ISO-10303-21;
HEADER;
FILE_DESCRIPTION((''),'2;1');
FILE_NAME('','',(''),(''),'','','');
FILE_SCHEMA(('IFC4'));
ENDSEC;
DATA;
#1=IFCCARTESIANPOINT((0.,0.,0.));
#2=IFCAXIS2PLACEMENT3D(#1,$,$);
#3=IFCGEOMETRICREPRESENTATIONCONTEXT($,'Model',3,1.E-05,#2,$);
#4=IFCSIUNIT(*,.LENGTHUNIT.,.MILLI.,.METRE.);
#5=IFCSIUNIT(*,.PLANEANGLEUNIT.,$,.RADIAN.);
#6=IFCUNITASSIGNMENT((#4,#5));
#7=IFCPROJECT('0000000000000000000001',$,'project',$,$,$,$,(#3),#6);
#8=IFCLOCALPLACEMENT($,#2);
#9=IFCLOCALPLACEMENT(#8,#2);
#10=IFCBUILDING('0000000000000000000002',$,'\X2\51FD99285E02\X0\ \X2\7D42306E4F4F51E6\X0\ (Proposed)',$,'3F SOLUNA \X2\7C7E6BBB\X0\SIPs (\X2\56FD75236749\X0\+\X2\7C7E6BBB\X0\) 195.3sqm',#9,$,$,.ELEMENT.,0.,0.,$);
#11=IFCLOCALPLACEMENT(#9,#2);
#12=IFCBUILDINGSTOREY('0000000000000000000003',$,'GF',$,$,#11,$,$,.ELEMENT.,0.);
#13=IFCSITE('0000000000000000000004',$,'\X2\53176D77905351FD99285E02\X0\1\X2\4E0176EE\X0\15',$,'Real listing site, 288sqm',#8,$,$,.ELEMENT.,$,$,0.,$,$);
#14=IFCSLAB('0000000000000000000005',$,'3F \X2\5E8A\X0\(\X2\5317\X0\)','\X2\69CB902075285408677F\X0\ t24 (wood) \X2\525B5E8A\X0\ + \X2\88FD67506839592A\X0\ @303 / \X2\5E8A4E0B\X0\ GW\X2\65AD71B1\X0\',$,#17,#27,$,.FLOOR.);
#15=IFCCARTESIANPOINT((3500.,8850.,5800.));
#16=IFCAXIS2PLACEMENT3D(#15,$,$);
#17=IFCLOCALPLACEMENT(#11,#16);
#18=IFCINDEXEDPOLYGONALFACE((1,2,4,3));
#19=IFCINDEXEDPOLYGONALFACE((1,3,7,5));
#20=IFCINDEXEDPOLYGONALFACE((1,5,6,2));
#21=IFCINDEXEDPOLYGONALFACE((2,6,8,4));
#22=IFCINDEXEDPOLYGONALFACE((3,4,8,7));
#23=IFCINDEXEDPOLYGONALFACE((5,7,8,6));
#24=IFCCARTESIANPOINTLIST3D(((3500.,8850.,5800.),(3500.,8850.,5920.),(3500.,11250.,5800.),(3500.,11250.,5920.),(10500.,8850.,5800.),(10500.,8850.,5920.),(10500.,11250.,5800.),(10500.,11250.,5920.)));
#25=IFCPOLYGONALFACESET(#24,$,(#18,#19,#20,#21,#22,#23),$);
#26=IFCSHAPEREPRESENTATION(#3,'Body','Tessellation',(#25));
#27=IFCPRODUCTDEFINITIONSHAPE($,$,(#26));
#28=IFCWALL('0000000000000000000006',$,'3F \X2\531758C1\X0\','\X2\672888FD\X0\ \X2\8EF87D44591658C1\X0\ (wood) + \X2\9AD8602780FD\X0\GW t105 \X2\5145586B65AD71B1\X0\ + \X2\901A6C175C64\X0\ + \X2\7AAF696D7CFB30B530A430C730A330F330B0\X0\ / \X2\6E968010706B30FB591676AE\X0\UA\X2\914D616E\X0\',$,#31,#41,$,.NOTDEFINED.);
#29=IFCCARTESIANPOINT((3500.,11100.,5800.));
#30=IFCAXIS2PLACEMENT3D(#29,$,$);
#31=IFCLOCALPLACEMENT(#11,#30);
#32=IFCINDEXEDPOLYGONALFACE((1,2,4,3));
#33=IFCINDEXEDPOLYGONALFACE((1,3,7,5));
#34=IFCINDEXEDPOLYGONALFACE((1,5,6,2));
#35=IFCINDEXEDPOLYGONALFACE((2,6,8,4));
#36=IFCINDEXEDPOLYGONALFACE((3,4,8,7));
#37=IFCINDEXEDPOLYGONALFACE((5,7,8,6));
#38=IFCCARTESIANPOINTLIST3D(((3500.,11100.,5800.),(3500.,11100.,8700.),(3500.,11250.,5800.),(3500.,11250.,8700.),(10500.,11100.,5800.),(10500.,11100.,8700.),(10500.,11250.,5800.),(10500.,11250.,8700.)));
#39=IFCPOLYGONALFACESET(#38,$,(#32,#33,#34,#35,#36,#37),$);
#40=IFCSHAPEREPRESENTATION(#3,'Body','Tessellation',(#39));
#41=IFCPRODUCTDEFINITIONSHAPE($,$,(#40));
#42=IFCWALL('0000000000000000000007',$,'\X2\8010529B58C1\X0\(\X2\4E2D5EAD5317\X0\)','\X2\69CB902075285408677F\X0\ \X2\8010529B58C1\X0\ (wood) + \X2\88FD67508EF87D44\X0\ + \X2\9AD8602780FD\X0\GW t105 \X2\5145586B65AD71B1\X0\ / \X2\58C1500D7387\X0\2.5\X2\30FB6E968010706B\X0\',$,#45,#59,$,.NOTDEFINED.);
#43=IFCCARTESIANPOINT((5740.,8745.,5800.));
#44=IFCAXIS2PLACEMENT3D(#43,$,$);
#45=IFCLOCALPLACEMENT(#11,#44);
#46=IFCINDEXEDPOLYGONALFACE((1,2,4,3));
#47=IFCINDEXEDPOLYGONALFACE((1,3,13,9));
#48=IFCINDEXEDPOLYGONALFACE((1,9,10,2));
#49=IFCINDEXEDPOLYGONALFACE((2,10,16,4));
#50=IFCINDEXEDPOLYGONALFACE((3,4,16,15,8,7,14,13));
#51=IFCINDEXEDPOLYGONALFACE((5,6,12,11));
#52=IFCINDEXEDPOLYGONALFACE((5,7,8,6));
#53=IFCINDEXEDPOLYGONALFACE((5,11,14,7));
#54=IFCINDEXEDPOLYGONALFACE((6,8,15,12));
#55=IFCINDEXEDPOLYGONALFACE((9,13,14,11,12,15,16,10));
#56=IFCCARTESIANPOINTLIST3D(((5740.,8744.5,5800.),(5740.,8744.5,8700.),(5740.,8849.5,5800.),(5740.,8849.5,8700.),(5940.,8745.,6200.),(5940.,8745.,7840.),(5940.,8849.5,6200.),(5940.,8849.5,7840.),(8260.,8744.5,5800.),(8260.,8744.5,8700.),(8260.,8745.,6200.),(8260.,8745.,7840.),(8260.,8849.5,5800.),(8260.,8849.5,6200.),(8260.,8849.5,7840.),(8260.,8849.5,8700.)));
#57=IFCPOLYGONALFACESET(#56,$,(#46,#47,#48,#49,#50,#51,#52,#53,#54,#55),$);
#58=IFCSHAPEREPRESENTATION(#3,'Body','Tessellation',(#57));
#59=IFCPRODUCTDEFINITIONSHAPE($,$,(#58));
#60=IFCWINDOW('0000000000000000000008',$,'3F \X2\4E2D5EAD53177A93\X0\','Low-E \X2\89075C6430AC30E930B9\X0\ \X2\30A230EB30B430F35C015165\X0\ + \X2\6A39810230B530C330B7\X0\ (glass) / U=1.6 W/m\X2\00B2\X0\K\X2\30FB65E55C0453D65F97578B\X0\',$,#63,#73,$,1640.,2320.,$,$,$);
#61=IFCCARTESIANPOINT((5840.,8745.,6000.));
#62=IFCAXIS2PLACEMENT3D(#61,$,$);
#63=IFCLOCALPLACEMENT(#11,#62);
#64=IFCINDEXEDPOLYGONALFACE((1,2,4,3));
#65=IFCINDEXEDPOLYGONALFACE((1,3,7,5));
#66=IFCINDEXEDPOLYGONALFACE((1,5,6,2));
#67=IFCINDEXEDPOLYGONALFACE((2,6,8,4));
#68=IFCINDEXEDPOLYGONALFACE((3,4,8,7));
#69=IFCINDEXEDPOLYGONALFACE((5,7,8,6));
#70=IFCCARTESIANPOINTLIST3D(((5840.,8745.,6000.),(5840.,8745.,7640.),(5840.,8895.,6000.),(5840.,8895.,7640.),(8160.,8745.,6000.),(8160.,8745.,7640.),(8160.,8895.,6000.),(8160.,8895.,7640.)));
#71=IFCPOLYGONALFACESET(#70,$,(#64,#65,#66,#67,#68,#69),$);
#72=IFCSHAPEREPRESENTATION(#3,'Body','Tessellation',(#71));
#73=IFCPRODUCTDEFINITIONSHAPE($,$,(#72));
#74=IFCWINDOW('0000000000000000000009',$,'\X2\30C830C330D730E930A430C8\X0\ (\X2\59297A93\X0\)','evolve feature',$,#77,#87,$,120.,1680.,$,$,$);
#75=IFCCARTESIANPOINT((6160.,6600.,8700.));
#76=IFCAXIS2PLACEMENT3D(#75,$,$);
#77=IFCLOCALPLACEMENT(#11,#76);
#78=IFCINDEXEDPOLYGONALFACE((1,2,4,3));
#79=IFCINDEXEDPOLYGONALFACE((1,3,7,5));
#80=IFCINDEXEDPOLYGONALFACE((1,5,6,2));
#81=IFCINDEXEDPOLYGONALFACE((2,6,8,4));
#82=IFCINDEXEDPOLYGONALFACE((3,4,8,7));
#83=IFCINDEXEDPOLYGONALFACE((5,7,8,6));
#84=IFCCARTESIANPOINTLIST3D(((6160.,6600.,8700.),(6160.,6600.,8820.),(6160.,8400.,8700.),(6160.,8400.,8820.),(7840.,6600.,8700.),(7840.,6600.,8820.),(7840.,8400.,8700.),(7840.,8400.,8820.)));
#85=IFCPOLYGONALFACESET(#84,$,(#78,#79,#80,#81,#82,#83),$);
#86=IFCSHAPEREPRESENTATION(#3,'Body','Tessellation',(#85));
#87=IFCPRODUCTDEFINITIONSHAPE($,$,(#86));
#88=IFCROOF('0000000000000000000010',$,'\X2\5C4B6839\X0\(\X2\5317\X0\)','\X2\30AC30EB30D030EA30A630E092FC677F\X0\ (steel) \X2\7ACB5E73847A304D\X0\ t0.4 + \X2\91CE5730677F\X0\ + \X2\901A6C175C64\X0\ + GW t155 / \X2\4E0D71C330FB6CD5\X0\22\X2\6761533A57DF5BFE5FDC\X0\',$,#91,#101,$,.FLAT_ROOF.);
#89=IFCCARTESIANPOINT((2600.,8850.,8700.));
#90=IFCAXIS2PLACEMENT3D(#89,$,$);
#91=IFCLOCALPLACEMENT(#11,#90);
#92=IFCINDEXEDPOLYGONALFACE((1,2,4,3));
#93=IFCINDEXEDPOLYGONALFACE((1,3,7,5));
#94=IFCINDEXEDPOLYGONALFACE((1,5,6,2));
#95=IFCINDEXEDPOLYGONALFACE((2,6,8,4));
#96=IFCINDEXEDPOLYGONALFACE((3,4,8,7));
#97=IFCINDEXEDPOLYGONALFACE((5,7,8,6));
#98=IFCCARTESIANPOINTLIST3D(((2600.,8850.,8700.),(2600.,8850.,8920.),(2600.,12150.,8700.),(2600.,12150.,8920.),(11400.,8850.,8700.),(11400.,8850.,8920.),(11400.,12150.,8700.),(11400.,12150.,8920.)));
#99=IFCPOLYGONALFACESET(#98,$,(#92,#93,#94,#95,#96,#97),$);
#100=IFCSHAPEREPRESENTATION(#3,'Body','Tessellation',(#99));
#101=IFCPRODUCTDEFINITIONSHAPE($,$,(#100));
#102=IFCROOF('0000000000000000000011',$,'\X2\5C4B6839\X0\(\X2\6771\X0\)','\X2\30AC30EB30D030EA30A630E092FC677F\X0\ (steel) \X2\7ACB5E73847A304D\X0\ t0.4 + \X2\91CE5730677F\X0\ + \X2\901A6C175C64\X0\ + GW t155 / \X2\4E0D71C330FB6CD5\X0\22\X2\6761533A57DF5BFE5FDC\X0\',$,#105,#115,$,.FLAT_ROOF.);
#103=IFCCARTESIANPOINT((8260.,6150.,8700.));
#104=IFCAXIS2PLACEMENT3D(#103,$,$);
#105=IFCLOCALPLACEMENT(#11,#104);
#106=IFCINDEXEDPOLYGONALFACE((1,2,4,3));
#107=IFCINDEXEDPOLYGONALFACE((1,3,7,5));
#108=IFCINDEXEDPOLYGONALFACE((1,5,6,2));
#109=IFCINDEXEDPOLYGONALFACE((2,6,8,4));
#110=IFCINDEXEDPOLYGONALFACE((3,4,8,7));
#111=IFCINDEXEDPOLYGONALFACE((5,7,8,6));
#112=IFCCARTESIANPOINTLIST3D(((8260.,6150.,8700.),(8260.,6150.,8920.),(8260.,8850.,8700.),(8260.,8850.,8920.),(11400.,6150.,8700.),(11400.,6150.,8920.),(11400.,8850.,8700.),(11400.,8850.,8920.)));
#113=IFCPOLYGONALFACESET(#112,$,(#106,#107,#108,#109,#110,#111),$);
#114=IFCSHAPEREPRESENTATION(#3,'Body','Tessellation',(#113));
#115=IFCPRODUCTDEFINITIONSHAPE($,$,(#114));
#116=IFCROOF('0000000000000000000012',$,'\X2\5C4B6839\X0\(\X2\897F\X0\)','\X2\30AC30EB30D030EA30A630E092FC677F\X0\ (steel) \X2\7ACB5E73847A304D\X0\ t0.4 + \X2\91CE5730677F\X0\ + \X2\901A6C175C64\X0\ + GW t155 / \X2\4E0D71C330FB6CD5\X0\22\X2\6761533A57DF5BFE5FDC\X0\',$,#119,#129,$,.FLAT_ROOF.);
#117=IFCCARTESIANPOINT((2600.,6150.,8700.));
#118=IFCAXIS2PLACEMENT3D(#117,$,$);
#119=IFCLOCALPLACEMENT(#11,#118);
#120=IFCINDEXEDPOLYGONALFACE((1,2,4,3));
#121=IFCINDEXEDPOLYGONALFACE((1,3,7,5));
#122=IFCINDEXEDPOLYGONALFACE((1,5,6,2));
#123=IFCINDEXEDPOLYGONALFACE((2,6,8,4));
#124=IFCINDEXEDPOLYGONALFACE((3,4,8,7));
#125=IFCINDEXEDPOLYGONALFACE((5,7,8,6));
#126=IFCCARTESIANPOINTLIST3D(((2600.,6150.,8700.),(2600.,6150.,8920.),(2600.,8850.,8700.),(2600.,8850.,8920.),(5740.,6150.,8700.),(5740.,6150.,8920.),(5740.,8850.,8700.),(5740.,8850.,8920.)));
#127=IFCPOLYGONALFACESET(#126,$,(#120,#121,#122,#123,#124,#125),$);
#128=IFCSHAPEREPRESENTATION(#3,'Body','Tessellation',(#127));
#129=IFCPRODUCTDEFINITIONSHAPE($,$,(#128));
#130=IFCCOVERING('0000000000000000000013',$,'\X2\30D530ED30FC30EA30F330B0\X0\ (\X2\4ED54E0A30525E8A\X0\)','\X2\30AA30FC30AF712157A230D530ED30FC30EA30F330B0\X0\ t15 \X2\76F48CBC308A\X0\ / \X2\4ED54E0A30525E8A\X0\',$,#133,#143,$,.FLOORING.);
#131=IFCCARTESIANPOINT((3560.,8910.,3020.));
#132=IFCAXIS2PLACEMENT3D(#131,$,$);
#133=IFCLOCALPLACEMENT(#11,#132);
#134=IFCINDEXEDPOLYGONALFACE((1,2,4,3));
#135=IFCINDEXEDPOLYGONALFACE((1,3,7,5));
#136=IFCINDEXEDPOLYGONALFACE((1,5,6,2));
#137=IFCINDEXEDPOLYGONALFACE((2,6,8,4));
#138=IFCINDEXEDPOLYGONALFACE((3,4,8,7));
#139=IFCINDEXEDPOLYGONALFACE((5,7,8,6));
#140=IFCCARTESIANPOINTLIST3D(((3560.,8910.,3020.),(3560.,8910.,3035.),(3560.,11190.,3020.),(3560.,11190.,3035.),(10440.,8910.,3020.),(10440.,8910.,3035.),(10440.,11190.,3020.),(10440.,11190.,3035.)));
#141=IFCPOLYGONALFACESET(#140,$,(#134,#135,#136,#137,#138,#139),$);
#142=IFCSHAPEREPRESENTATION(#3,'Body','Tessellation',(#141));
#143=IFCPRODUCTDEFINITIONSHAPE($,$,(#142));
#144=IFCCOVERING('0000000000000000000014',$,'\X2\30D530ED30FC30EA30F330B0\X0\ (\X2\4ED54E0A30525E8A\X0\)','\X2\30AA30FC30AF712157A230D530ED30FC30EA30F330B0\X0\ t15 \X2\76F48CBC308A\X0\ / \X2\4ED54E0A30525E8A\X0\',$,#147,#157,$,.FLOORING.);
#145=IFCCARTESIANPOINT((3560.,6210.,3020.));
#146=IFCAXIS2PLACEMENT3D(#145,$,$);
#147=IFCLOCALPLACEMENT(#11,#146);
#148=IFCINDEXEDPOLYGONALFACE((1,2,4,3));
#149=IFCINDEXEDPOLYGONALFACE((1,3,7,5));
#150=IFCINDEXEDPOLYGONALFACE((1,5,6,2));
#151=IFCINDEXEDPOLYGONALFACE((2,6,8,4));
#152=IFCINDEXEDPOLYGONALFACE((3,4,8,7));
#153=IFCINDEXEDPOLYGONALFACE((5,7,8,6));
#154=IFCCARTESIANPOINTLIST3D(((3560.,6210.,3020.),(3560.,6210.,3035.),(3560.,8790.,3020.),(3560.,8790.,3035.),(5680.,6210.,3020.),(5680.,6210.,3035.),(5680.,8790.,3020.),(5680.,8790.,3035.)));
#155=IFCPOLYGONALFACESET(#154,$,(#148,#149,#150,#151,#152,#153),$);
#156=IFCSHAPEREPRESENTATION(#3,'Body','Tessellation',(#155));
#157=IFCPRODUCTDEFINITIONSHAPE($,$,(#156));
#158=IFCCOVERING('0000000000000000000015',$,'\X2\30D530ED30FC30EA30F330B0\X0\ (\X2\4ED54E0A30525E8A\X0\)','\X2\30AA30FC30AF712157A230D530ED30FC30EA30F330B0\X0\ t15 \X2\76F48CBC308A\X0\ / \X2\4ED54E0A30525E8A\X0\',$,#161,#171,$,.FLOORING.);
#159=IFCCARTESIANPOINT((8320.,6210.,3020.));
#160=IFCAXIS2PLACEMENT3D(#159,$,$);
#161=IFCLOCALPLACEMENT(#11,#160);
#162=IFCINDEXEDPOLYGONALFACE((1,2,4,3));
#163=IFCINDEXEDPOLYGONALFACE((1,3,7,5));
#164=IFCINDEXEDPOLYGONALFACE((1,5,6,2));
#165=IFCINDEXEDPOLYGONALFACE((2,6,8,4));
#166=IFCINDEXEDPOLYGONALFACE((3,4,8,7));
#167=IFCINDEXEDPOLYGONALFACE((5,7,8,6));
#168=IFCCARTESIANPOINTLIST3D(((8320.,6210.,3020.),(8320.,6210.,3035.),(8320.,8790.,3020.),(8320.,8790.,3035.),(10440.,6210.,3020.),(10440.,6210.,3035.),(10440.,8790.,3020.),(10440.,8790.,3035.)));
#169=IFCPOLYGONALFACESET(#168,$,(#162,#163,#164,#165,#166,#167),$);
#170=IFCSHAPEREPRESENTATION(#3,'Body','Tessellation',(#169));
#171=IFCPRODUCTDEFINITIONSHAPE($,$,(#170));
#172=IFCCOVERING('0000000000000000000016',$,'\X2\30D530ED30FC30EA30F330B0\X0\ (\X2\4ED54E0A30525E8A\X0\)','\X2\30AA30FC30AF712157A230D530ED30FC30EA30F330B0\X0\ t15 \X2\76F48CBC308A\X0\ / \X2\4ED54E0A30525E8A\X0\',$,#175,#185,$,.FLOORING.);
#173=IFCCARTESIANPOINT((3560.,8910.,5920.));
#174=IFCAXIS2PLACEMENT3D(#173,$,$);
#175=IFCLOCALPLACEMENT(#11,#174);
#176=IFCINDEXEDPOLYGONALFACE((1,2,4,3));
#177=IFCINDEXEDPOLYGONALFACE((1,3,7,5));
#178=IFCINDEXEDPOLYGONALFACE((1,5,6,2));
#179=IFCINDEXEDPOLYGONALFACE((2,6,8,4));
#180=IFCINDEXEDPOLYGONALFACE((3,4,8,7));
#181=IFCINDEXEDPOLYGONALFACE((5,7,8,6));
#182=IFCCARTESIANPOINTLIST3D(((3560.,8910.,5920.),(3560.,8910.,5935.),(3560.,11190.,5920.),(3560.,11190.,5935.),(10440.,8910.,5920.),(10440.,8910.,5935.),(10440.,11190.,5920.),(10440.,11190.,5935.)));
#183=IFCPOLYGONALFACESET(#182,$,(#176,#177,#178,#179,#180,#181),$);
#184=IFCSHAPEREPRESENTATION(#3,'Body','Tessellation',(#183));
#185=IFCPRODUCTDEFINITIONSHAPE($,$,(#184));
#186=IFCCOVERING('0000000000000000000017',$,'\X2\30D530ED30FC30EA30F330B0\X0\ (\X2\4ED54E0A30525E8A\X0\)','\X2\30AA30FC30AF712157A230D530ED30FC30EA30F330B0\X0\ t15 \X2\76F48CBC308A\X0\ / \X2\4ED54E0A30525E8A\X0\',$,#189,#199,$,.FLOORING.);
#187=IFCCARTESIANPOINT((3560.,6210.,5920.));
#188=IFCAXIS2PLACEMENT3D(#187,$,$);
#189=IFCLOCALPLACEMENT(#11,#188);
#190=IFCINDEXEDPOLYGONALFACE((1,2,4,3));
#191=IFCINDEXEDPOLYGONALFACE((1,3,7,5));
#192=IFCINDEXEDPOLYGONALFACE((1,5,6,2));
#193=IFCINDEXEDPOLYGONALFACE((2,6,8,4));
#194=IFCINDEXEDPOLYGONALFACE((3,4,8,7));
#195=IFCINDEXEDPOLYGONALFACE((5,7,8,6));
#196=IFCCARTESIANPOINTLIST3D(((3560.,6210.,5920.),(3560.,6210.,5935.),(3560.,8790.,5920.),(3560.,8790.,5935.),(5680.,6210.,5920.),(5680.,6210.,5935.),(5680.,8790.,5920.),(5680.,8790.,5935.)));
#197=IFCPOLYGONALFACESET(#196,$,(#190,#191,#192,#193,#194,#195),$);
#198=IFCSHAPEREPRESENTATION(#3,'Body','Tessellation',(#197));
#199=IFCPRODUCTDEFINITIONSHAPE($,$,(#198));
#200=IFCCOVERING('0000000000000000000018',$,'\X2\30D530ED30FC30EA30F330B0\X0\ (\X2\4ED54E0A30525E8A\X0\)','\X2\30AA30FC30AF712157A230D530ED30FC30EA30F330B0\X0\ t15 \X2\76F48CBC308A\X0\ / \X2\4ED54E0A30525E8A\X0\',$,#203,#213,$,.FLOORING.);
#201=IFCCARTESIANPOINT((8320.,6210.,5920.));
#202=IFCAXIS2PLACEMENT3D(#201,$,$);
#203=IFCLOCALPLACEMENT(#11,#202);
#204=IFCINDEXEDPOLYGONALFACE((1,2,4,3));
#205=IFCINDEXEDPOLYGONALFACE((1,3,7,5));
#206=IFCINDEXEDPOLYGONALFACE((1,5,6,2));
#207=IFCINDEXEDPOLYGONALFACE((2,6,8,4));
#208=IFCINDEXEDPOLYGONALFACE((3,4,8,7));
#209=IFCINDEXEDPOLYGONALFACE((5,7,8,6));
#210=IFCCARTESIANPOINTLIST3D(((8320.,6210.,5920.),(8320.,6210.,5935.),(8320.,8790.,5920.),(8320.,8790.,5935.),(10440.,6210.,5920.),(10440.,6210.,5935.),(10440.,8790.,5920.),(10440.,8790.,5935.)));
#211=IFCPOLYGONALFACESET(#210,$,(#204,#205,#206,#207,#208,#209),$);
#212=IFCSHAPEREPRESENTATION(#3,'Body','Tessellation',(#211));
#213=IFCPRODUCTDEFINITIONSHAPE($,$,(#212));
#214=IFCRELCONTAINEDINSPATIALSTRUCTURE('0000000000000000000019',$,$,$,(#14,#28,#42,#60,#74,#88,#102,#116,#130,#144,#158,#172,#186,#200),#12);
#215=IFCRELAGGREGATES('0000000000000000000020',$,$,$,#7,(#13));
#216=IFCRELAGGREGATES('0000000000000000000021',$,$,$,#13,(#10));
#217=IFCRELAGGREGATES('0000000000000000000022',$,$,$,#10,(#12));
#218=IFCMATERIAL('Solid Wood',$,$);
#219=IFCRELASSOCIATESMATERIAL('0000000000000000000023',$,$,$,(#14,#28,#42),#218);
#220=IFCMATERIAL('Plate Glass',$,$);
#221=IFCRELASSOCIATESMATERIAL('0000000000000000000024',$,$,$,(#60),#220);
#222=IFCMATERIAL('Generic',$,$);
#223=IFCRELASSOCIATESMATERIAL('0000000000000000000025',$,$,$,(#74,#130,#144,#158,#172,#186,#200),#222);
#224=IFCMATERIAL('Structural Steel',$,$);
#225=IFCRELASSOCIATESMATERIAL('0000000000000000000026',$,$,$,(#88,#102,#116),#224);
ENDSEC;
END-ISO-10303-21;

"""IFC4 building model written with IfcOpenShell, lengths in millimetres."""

from ifc_helpers import new_model, si_unit, frame, frame_2d, origin, place, context, project, spatial, rectangle, extrude, material, element, fill, save


model = new_model("IFC4")

# Units and contexts
model_context = context("Model", 3, precision=1e-05, world=origin())
ifc_project = project(units=[si_unit("LENGTHUNIT", "METRE", prefix="MILLI"), si_unit("PLANEANGLEUNIT", "RADIAN")], contexts=[model_context])

# Site, building, storey
site_placement = place(None, origin())
site = spatial("IfcSite", under=ifc_project, at=site_placement, Name="北海道函館市1丁目15", ObjectType="Real listing site, 288sqm", CompositionType="ELEMENT", RefElevation=0.0)
building_placement = place(site_placement, origin())
building = spatial("IfcBuilding", under=site, at=building_placement, Name="函館市 終の住処 (Proposed)", ObjectType="3F SOLUNA 籾殻SIPs (国産杉+籾殻) 195.3sqm", CompositionType="ELEMENT", ElevationOfRefHeight=0.0, ElevationOfTerrain=0.0)
storey_placement = place(building_placement, origin())
storey = spatial("IfcBuildingStorey", under=building, at=storey_placement, Name="GF", CompositionType="ELEMENT", Elevation=0.0)

# Slab
ifc_material_1 = material(Name="Solid Wood")
slab_placement = place(storey_placement, frame((3500.0, 8850.0, 5800.0)))
element("IfcSlab", 1, at=slab_placement, inside=storey, material=ifc_material_1, Name="3F 床(北)", Description="構造用合板 t24 (wood) 剛床 + 製材根太 @303 / 床下 GW断熱", PredefinedType="FLOOR", context=model_context, shape_type="SweptSolid", body=[
    extrude(rectangle(XDim=7000.0, YDim=2400.0, at=frame_2d((3500.0, 1200.0))), frame((3500.0, 8850.0, 5800.0)), (0.0, 0.0, 1.0), 120.0),
])

# Wall
wall_1_placement = place(storey_placement, frame((3500.0, 11100.0, 5800.0)))
element("IfcWall", 2, at=wall_1_placement, inside=storey, material=ifc_material_1, Name="3F 北壁", Description="木製 軸組外壁 (wood) + 高性能GW t105 充填断熱 + 通気層 + 窯業系サイディング / 準耐火・外皮UA配慮", PredefinedType="NOTDEFINED", context=model_context, shape_type="SweptSolid", body=[
    extrude(rectangle(XDim=7000.0, YDim=150.0, at=frame_2d((3500.0, 75.0))), frame((3500.0, 11100.0, 5800.0)), (0.0, 0.0, 1.0), 2900.0),
])

# Wall, opening, window
wall_2_placement = place(storey_placement, frame((5740.0, 8745.0, 5800.0)))
wall_2 = element("IfcWall", 3, at=wall_2_placement, inside=storey, material=ifc_material_1, Name="耐力壁(中庭北)", Description="構造用合板 耐力壁 (wood) + 製材軸組 + 高性能GW t105 充填断熱 / 壁倍率2.5・準耐火", PredefinedType="NOTDEFINED", context=model_context, shape_type="SweptSolid", body=[
    extrude(rectangle(XDim=2520.0, YDim=105.0, at=frame_2d((1260.0, 52.0))), frame((5740.0, 8745.0, 5800.0)), (0.0, 0.0, 1.0), 2900.0),
])
opening_placement = place(storey_placement, frame((5840.0, 8745.0, 6000.0)))
opening = element("IfcOpeningElement", 4, at=opening_placement, cuts=wall_2, PredefinedType="NOTDEFINED", context=model_context, shape_type="SweptSolid", body=[
    extrude(rectangle(XDim=2320.0, YDim=150.0, at=frame_2d((1160.0, 75.0))), frame((5840.0, 8745.0, 6000.0)), (0.0, 0.0, 1.0), 1640.0),
])
ifc_material_2 = material(Name="Plate Glass")
window_1_placement = place(storey_placement, frame((5840.0, 8745.0, 6000.0)))
window_1 = element("IfcWindow", 5, at=window_1_placement, inside=storey, material=ifc_material_2, Name="3F 中庭北窓", Description="Low-E 複層ガラス アルゴン封入 + 樹脂サッシ (glass) / U=1.6 W/m²K・日射取得型", OverallHeight=1640.0, OverallWidth=2320.0, context=model_context, shape_type="SweptSolid", body=[
    extrude(rectangle(XDim=2320.0, YDim=150.0, at=frame_2d((1160.0, 75.0))), frame((5840.0, 8745.0, 6000.0)), (0.0, 0.0, 1.0), 1640.0),
])
fill(opening, window_1)

# Window
ifc_material_3 = material(Name="Generic")
window_2_placement = place(storey_placement, frame((6160.0, 6600.0, 8700.0)))
element("IfcWindow", 6, at=window_2_placement, inside=storey, material=ifc_material_3, Name="トップライト (天窓)", Description="evolve feature", OverallHeight=120.0, OverallWidth=1680.0, context=model_context, shape_type="SweptSolid", body=[
    extrude(rectangle(XDim=1680.0, YDim=1800.0, at=frame_2d((840.0, 900.0))), frame((6160.0, 6600.0, 8700.0)), (0.0, 0.0, 1.0), 120.0),
])

# Roofs
ifc_material_4 = material(Name="Structural Steel")
roof_1_placement = place(storey_placement, frame((2600.0, 8850.0, 8700.0)))
element("IfcRoof", 7, at=roof_1_placement, inside=storey, material=ifc_material_4, Name="屋根(北)", Description="ガルバリウム鋼板 (steel) 立平葺き t0.4 + 野地板 + 通気層 + GW t155 / 不燃・法22条区域対応", PredefinedType="FLAT_ROOF", context=model_context, shape_type="SweptSolid", body=[
    extrude(rectangle(XDim=8800.0, YDim=3300.0, at=frame_2d((4400.0, 1650.0))), frame((2600.0, 8850.0, 8700.0)), (0.0, 0.0, 1.0), 220.0),
])
roof_2_placement = place(storey_placement, frame((8260.0, 6150.0, 8700.0)))
element("IfcRoof", 8, at=roof_2_placement, inside=storey, material=ifc_material_4, Name="屋根(東)", Description="ガルバリウム鋼板 (steel) 立平葺き t0.4 + 野地板 + 通気層 + GW t155 / 不燃・法22条区域対応", PredefinedType="FLAT_ROOF", context=model_context, shape_type="SweptSolid", body=[
    extrude(rectangle(XDim=3140.0, YDim=2700.0, at=frame_2d((1570.0, 1350.0))), frame((8260.0, 6150.0, 8700.0)), (0.0, 0.0, 1.0), 220.0),
])
roof_3_placement = place(storey_placement, frame((2600.0, 6150.0, 8700.0)))
element("IfcRoof", 9, at=roof_3_placement, inside=storey, material=ifc_material_4, Name="屋根(西)", Description="ガルバリウム鋼板 (steel) 立平葺き t0.4 + 野地板 + 通気層 + GW t155 / 不燃・法22条区域対応", PredefinedType="FLAT_ROOF", context=model_context, shape_type="SweptSolid", body=[
    extrude(rectangle(XDim=3140.0, YDim=2700.0, at=frame_2d((1570.0, 1350.0))), frame((2600.0, 6150.0, 8700.0)), (0.0, 0.0, 1.0), 220.0),
])

# Coverings
covering_1_placement = place(storey_placement, frame((3560.0, 8910.0, 3020.0)))
element("IfcCovering", 10, at=covering_1_placement, inside=storey, material=ifc_material_3, Name="フローリング (仕上げ床)", Description="オーク無垢フローリング t15 直貼り / 仕上げ床", PredefinedType="FLOORING", context=model_context, shape_type="SweptSolid", body=[
    extrude(rectangle(XDim=6880.0, YDim=2280.0, at=frame_2d((3440.0, 1140.0))), frame((3560.0, 8910.0, 3020.0)), (0.0, 0.0, 1.0), 15.0),
])
covering_2_placement = place(storey_placement, frame((3560.0, 6210.0, 3020.0)))
element("IfcCovering", 11, at=covering_2_placement, inside=storey, material=ifc_material_3, Name="フローリング (仕上げ床)", Description="オーク無垢フローリング t15 直貼り / 仕上げ床", PredefinedType="FLOORING", context=model_context, shape_type="SweptSolid", body=[
    extrude(rectangle(XDim=2120.0, YDim=2580.0, at=frame_2d((1060.0, 1290.0))), frame((3560.0, 6210.0, 3020.0)), (0.0, 0.0, 1.0), 15.0),
])
covering_3_placement = place(storey_placement, frame((8320.0, 6210.0, 3020.0)))
element("IfcCovering", 12, at=covering_3_placement, inside=storey, material=ifc_material_3, Name="フローリング (仕上げ床)", Description="オーク無垢フローリング t15 直貼り / 仕上げ床", PredefinedType="FLOORING", context=model_context, shape_type="SweptSolid", body=[
    extrude(rectangle(XDim=2120.0, YDim=2580.0, at=frame_2d((1060.0, 1290.0))), frame((8320.0, 6210.0, 3020.0)), (0.0, 0.0, 1.0), 15.0),
])
covering_4_placement = place(storey_placement, frame((3560.0, 8910.0, 5920.0)))
element("IfcCovering", 13, at=covering_4_placement, inside=storey, material=ifc_material_3, Name="フローリング (仕上げ床)", Description="オーク無垢フローリング t15 直貼り / 仕上げ床", PredefinedType="FLOORING", context=model_context, shape_type="SweptSolid", body=[
    extrude(rectangle(XDim=6880.0, YDim=2280.0, at=frame_2d((3440.0, 1140.0))), frame((3560.0, 8910.0, 5920.0)), (0.0, 0.0, 1.0), 15.0),
])
covering_5_placement = place(storey_placement, frame((3560.0, 6210.0, 5920.0)))
element("IfcCovering", 14, at=covering_5_placement, inside=storey, material=ifc_material_3, Name="フローリング (仕上げ床)", Description="オーク無垢フローリング t15 直貼り / 仕上げ床", PredefinedType="FLOORING", context=model_context, shape_type="SweptSolid", body=[
    extrude(rectangle(XDim=2120.0, YDim=2580.0, at=frame_2d((1060.0, 1290.0))), frame((3560.0, 6210.0, 5920.0)), (0.0, 0.0, 1.0), 15.0),
])
covering_6_placement = place(storey_placement, frame((8320.0, 6210.0, 5920.0)))
element("IfcCovering", 15, at=covering_6_placement, inside=storey, material=ifc_material_3, Name="フローリング (仕上げ床)", Description="オーク無垢フローリング t15 直貼り / 仕上げ床", PredefinedType="FLOORING", context=model_context, shape_type="SweptSolid", body=[
    extrude(rectangle(XDim=2120.0, YDim=2580.0, at=frame_2d((1060.0, 1290.0))), frame((8320.0, 6210.0, 5920.0)), (0.0, 0.0, 1.0), 15.0),
])

save(model, "model.ifc")
